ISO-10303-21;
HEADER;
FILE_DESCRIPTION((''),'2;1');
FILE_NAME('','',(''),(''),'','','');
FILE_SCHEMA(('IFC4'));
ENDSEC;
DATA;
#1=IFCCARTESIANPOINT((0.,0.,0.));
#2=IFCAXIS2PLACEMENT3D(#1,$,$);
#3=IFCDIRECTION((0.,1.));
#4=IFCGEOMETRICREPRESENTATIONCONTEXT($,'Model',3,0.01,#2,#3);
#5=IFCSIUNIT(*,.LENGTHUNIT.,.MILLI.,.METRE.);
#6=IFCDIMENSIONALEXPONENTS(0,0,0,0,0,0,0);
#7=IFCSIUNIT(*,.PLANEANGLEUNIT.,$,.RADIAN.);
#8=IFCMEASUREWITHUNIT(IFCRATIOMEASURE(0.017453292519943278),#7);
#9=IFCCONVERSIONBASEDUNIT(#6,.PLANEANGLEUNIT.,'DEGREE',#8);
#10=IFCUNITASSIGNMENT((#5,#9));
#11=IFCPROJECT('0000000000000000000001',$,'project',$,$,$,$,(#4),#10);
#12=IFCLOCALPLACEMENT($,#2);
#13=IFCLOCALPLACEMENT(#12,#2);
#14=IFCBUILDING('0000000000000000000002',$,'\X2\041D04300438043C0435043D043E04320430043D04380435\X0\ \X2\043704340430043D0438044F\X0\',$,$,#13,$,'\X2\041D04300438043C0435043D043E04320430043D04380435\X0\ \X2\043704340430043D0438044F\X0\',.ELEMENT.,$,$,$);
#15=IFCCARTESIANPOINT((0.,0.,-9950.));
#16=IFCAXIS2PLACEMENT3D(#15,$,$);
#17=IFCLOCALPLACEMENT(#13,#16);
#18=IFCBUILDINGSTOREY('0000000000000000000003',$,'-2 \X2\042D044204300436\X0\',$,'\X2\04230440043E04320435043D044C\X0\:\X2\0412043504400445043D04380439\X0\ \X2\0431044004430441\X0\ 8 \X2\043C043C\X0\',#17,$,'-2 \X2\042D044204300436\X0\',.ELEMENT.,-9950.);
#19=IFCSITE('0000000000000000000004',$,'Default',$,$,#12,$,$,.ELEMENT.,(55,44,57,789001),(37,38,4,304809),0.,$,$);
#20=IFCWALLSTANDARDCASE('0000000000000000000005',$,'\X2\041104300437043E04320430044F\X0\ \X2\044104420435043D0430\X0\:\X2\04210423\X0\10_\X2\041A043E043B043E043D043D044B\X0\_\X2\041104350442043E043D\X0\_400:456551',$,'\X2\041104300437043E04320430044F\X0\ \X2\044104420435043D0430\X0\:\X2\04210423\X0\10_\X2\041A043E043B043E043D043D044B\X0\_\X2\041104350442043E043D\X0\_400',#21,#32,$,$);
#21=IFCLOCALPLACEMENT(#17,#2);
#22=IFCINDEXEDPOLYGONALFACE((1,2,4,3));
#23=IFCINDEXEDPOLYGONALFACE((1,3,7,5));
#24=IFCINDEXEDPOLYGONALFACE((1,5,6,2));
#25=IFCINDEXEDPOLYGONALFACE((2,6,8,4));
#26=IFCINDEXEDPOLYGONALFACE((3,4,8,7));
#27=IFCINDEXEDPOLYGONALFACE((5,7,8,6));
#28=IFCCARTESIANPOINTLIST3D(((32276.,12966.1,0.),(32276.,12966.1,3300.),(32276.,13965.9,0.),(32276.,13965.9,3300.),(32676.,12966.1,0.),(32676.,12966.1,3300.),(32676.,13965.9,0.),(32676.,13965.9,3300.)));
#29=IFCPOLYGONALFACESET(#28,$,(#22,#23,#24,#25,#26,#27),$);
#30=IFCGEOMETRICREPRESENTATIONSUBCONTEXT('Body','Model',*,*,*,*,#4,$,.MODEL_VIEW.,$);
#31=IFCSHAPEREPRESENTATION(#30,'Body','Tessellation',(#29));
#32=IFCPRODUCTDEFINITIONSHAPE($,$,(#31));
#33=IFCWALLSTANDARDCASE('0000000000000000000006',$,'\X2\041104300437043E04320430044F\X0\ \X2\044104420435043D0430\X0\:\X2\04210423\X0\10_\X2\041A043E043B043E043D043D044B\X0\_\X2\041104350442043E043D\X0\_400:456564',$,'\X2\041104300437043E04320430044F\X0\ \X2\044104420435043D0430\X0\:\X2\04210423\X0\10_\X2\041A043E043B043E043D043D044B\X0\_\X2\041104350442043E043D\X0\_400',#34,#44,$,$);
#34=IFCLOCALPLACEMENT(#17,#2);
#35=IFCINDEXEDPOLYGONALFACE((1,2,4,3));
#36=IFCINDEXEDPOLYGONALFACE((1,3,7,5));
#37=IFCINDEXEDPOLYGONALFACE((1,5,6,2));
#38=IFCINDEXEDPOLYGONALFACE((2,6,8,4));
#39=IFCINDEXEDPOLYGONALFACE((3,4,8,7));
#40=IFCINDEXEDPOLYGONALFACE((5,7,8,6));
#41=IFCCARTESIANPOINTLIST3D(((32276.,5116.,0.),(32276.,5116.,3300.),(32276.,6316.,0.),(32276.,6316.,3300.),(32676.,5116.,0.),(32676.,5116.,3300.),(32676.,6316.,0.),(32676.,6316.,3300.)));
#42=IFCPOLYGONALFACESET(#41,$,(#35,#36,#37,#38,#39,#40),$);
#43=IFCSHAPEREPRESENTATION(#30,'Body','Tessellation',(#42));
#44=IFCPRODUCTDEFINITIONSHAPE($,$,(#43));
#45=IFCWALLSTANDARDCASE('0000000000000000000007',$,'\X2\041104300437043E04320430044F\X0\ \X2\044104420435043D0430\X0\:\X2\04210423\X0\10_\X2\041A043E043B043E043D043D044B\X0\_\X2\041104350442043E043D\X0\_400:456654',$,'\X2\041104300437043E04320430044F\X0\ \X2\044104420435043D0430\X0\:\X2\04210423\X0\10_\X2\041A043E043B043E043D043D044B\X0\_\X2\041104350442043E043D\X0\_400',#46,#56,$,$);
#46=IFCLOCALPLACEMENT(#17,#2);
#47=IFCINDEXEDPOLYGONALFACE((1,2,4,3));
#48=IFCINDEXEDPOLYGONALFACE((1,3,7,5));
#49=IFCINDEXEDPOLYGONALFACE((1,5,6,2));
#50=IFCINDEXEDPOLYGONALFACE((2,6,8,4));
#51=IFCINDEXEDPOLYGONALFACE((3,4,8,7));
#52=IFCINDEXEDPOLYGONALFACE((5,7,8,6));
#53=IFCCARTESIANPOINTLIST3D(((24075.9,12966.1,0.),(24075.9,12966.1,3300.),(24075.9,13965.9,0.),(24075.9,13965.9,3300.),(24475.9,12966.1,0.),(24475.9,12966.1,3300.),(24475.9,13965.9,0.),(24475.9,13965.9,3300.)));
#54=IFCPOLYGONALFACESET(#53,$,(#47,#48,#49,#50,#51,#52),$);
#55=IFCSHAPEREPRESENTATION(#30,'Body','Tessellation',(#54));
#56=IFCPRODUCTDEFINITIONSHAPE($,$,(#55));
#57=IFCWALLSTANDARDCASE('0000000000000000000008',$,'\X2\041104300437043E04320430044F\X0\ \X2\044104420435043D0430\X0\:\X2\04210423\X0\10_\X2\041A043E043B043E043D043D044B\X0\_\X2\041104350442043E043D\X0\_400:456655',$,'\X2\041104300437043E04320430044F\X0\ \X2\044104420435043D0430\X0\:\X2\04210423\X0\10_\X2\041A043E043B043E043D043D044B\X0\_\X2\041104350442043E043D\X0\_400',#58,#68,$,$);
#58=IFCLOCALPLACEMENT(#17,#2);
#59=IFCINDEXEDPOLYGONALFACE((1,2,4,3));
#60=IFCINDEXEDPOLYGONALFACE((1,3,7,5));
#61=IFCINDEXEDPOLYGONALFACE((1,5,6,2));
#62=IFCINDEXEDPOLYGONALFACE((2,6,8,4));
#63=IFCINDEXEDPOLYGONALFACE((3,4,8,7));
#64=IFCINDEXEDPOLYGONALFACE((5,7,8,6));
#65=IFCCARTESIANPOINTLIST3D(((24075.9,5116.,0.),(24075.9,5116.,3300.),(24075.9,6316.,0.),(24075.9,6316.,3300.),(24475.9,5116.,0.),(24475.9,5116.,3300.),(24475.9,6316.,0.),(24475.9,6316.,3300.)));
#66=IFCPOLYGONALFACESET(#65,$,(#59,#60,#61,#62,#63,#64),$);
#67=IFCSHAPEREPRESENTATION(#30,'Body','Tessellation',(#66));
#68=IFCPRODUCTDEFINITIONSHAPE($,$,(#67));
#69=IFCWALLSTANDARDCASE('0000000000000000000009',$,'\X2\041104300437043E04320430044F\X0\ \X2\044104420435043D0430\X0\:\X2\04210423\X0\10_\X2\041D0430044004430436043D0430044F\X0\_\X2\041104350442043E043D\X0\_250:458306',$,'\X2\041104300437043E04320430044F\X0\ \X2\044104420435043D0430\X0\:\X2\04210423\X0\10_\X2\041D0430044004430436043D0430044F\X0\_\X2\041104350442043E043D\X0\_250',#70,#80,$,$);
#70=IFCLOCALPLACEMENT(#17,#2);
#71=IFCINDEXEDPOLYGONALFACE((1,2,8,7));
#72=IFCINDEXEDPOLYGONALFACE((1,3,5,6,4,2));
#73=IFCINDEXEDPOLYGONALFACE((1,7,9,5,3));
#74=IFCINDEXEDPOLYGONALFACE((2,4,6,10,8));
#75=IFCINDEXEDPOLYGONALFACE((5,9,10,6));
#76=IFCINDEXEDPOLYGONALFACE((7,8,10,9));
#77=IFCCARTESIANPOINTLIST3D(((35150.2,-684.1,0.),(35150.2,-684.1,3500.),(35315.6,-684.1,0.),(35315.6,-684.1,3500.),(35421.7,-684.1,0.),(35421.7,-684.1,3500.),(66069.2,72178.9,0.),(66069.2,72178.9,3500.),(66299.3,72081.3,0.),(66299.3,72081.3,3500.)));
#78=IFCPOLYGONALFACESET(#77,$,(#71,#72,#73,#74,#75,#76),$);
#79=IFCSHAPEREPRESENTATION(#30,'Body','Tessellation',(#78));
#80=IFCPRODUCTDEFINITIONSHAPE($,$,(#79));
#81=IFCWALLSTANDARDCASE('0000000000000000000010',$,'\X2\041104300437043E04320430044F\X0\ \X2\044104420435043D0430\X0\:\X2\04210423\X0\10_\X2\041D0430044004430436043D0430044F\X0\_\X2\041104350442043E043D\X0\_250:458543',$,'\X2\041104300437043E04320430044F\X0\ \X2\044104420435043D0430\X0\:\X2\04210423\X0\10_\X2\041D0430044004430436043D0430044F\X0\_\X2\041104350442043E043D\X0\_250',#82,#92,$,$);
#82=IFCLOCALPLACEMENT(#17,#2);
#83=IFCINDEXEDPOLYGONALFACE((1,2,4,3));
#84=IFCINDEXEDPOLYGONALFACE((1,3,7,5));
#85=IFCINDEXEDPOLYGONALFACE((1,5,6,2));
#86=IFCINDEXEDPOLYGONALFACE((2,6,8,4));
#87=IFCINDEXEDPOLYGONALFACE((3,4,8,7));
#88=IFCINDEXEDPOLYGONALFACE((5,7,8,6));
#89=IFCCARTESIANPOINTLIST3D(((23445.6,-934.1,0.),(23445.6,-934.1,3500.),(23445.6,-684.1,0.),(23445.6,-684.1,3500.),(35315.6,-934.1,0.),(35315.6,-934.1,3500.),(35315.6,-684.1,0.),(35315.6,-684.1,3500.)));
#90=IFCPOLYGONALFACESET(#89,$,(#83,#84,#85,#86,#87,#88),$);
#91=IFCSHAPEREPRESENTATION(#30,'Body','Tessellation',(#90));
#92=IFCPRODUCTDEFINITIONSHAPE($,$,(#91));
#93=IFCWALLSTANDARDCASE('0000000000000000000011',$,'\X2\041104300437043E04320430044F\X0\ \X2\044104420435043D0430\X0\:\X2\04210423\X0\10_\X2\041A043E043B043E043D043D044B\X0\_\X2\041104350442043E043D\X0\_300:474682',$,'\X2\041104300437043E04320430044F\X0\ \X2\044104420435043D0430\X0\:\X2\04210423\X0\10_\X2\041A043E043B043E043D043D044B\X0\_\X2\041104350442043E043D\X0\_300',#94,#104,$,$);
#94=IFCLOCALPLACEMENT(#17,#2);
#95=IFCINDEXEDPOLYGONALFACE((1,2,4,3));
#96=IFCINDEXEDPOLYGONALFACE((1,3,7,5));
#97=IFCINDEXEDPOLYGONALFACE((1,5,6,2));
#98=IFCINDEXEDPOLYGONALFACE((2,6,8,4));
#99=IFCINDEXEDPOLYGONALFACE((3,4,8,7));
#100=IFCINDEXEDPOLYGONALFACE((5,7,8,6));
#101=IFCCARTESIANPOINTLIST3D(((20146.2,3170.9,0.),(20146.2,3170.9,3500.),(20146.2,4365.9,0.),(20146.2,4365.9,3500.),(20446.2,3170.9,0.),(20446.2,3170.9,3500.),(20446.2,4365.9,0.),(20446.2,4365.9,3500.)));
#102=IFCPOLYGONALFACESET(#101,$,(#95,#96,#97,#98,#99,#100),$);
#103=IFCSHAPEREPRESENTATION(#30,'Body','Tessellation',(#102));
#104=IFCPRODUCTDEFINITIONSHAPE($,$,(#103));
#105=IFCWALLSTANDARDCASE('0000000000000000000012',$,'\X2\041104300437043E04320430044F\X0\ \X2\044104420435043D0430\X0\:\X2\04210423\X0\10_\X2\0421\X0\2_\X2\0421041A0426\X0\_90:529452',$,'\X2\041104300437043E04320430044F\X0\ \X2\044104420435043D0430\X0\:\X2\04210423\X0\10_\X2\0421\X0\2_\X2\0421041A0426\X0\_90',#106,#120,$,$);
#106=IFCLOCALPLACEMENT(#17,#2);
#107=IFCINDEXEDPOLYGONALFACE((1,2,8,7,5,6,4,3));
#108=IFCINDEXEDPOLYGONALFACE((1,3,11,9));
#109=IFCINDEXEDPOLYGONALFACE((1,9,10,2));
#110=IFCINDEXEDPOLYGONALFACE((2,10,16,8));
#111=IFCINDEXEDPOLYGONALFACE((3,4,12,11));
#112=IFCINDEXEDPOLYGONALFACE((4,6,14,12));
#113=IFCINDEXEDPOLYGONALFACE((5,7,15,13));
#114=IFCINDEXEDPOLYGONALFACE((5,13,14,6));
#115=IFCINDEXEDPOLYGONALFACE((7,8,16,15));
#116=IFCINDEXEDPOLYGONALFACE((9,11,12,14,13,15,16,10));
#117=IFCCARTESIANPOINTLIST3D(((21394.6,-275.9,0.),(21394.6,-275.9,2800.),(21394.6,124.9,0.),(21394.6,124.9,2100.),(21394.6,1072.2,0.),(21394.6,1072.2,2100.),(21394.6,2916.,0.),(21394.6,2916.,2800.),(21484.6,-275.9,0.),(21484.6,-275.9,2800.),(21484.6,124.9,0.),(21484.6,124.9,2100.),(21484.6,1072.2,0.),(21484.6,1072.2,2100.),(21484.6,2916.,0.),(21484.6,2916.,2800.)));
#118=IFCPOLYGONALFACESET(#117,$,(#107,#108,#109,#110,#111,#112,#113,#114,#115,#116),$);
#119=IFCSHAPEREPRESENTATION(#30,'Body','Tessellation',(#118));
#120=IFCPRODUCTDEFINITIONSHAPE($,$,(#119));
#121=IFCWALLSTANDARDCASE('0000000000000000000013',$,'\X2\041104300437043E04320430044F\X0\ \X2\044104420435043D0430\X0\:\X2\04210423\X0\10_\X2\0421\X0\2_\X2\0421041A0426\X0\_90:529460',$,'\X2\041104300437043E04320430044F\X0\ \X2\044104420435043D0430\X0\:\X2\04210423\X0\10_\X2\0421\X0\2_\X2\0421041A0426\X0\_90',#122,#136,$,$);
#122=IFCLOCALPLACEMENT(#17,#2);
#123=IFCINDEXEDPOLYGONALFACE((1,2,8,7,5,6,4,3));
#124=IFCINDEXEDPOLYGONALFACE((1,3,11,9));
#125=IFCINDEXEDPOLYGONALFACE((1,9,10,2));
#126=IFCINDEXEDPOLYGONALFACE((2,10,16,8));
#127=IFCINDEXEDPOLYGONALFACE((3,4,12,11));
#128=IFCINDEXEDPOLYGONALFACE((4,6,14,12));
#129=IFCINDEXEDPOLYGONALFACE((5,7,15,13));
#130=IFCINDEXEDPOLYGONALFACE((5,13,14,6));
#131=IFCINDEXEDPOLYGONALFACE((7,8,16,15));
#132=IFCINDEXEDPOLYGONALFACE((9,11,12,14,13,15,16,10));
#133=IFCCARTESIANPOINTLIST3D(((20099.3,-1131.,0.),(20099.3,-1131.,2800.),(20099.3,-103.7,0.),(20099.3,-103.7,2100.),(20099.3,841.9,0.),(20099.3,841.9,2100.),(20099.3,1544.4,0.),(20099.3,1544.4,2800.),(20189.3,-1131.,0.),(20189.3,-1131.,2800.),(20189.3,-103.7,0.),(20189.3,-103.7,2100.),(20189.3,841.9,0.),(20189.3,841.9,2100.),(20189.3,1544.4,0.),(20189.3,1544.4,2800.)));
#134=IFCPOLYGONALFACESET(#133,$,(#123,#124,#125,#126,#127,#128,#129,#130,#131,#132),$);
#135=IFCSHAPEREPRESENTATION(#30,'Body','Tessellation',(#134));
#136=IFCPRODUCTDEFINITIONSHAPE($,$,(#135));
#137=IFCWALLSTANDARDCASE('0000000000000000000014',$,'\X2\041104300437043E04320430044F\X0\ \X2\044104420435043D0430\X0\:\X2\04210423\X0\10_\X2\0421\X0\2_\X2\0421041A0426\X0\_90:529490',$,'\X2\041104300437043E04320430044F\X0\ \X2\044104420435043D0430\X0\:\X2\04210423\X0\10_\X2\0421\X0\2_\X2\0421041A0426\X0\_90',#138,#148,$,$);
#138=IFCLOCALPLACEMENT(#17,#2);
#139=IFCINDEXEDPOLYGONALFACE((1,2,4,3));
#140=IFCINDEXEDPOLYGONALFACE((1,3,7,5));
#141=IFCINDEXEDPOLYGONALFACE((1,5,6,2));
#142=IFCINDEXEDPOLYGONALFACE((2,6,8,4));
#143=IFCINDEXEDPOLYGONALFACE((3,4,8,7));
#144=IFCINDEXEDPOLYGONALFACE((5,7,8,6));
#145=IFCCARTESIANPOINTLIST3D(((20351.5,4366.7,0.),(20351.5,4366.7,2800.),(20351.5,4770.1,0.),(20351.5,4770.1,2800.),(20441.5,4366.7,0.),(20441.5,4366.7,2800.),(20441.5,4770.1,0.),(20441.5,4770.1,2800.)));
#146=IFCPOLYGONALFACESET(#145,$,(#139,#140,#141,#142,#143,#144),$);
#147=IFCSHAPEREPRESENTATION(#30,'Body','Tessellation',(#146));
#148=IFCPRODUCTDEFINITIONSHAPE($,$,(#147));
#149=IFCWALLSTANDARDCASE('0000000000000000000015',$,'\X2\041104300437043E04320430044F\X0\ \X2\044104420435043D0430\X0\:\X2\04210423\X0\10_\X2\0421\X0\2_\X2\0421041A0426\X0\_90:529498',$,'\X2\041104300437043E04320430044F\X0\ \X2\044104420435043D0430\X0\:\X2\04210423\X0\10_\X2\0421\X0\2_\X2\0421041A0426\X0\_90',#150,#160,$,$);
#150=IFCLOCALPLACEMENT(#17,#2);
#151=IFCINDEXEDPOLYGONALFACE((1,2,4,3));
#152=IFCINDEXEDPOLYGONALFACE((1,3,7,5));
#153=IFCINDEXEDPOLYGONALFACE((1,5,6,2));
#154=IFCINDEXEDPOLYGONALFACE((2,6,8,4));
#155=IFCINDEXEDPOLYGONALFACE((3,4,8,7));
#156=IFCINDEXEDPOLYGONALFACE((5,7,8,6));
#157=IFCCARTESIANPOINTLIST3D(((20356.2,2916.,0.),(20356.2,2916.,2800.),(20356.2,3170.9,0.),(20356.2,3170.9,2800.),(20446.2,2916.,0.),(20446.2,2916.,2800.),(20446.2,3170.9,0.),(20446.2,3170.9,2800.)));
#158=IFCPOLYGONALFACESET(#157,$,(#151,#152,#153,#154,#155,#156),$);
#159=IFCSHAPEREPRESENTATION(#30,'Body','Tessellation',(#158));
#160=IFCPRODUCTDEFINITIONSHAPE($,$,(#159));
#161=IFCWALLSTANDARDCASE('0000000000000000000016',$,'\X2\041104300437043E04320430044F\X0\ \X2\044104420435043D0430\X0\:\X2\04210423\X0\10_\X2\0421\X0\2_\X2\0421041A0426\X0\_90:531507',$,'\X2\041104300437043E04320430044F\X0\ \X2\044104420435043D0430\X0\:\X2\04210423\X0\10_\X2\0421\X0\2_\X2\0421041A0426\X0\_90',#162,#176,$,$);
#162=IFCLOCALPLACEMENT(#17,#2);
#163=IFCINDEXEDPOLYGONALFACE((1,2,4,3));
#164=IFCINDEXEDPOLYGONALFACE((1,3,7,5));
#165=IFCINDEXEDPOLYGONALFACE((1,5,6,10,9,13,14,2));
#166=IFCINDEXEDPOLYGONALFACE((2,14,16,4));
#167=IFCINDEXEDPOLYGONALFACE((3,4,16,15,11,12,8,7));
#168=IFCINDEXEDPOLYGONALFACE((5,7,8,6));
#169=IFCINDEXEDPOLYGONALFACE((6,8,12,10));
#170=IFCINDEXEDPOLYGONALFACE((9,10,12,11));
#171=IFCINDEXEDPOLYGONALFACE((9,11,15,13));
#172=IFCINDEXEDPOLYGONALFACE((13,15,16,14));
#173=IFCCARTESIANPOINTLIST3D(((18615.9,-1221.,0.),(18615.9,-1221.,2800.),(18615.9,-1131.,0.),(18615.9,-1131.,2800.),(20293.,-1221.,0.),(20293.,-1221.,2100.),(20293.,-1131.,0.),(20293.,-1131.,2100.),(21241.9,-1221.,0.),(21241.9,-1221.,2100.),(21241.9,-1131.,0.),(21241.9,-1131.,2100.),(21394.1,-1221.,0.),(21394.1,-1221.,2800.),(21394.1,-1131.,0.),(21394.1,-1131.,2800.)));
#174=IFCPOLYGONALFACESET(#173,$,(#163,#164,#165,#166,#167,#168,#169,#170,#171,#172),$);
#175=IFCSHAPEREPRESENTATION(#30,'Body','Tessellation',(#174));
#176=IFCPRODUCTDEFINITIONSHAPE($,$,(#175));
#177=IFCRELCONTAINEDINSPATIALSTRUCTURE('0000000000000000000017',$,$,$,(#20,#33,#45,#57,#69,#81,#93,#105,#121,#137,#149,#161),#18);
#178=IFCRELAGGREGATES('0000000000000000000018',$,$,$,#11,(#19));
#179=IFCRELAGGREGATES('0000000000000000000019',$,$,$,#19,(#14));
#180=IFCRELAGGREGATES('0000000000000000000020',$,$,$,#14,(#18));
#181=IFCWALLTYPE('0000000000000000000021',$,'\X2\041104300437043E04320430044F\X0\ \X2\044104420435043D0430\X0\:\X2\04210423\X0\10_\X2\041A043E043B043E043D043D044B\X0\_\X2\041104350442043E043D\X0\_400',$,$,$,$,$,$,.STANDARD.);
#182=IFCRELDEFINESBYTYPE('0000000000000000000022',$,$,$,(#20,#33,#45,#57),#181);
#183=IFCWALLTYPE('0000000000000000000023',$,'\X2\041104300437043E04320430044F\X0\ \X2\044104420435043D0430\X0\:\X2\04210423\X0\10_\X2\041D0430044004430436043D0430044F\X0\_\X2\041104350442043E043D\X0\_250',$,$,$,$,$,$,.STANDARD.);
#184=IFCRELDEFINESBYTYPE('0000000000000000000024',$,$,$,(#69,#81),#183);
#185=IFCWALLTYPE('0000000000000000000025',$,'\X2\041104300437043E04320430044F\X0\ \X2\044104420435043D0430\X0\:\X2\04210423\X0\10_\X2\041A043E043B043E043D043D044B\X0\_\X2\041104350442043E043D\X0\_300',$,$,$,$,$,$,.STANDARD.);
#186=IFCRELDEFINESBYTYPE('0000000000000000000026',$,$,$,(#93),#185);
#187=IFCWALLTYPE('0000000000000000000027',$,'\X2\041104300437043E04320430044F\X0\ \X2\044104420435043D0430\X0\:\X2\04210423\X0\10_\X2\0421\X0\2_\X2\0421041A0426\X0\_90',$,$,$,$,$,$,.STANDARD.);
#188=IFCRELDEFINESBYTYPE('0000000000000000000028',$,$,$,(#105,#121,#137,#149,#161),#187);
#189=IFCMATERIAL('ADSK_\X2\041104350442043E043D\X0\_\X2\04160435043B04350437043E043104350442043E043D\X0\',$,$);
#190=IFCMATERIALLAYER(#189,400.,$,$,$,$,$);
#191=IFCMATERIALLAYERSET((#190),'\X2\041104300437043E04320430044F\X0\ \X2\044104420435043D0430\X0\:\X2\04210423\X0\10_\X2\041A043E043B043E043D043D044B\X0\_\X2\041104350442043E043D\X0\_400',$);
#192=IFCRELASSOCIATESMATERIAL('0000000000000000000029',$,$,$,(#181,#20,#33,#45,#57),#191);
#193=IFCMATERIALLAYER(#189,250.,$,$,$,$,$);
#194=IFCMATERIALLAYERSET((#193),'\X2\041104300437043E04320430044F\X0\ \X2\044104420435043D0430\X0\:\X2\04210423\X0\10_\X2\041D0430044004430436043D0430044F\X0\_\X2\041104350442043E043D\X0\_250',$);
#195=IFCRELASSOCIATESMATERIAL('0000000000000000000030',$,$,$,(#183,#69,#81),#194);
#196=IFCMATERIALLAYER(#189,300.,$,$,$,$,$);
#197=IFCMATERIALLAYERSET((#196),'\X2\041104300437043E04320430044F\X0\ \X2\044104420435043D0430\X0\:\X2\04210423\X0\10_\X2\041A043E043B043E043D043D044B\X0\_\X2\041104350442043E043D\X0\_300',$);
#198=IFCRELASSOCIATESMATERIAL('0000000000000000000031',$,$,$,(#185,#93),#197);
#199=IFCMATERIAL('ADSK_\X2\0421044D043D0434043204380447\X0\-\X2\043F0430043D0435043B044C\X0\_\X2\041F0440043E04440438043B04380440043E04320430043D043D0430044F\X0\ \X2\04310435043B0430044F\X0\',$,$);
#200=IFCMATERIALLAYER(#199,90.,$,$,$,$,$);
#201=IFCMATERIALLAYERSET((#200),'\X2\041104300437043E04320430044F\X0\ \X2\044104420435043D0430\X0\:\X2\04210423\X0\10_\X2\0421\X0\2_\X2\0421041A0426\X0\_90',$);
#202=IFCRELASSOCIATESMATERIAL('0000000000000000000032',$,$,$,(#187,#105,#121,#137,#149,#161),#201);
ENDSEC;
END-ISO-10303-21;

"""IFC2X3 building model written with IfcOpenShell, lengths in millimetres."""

from ifc_helpers import new_model, entity, si_unit, converted_unit, direction, frame, frame_2d, origin, place, context, subcontext, project, spatial, polyline, rectangle, outline, extrude, material, layer, layer_set, layer_usage, type_object, element, save


model = new_model("IFC2X3")

# Units and contexts
model_context = context("Model", 3, precision=0.01, world=origin(), true_north=direction((0.0, 1.0)))
body_context = subcontext(model_context, "Body", "Model", "MODEL_VIEW")
ifc_project = project(units=[si_unit("LENGTHUNIT", "METRE", prefix="MILLI"), converted_unit("PLANEANGLEUNIT", "DEGREE", entity("IfcRatioMeasure", 0.017453292519943278), si_unit("PLANEANGLEUNIT", "RADIAN"), dimensions=[0, 0, 0, 0, 0, 0, 0])], contexts=[model_context])

# Site, building, storey
site_placement = place(None, origin())
site = spatial("IfcSite", under=ifc_project, at=site_placement, Name="Default", CompositionType="ELEMENT", RefLatitude=(55, 44, 57, 789001), RefLongitude=(37, 38, 4, 304809), RefElevation=0.0)
building_placement = place(site_placement, origin())
building = spatial("IfcBuilding", under=site, at=building_placement, Name="Наименование здания", LongName="Наименование здания", CompositionType="ELEMENT")
storey_placement = place(building_placement, frame((0.0, 0.0, -9950.0)))
storey = spatial("IfcBuildingStorey", under=building, at=storey_placement, Name="-2 Этаж", ObjectType="Уровень:Верхний брус 8 мм", LongName="-2 Этаж", CompositionType="ELEMENT", Elevation=-9950.0)

# Walls
ifc_material_1 = material(Name="ADSK_Бетон_Железобетон")
ifc_layer_1 = layer(ifc_material_1, 400.0)
ifc_layer_set_1 = layer_set([ifc_layer_1], Name="Базовая стена:СУ10_Колонны_Бетон_400")
ifc_layer_usage_1 = layer_usage(ifc_layer_set_1, "AXIS2", "NEGATIVE", 200.0)
wall_type_1 = type_object("IfcWallType", Name="Базовая стена:СУ10_Колонны_Бетон_400", PredefinedType="STANDARD", material=ifc_layer_set_1)
wall_1_placement = place(storey_placement, frame((32476.0, 12966.1, 0.0), z_axis=(0.0, 0.0, 1.0), x_axis=(0.0, 1.0, 0.0)))
element("IfcWallStandardCase", 1, at=wall_1_placement, inside=storey, type_object=wall_type_1, material=ifc_layer_usage_1, Name="Базовая стена:СУ10_Колонны_Бетон_400:456551", ObjectType="Базовая стена:СУ10_Колонны_Бетон_400", context=body_context, shape_type="SweptSolid", body=[
    extrude(rectangle(XDim=999.8, YDim=400.0, at=frame_2d((499.9, 0.0), x_axis=(-1.0, 0.0))), origin(), (0.0, 0.0, 1.0), 3300.0),
])
wall_2_placement = place(storey_placement, frame((32476.0, 5116.0, 0.0), z_axis=(0.0, 0.0, 1.0), x_axis=(0.0, 1.0, 0.0)))
element("IfcWallStandardCase", 2, at=wall_2_placement, inside=storey, type_object=wall_type_1, material=ifc_layer_usage_1, Name="Базовая стена:СУ10_Колонны_Бетон_400:456564", ObjectType="Базовая стена:СУ10_Колонны_Бетон_400", context=body_context, shape_type="SweptSolid", body=[
    extrude(rectangle(XDim=1200.0, YDim=400.0, at=frame_2d((600.0, 0.0), x_axis=(-1.0, 0.0))), origin(), (0.0, 0.0, 1.0), 3300.0),
])
wall_3_placement = place(storey_placement, frame((24275.9, 12966.1, 0.0), z_axis=(0.0, 0.0, 1.0), x_axis=(0.0, 1.0, 0.0)))
element("IfcWallStandardCase", 3, at=wall_3_placement, inside=storey, type_object=wall_type_1, material=ifc_layer_usage_1, Name="Базовая стена:СУ10_Колонны_Бетон_400:456654", ObjectType="Базовая стена:СУ10_Колонны_Бетон_400", context=body_context, shape_type="SweptSolid", body=[
    extrude(rectangle(XDim=999.8, YDim=400.0, at=frame_2d((499.9, 0.0), x_axis=(-1.0, 0.0))), origin(), (0.0, 0.0, 1.0), 3300.0),
])
wall_4_placement = place(storey_placement, frame((24275.9, 5116.0, 0.0), z_axis=(0.0, 0.0, 1.0), x_axis=(0.0, 1.0, 0.0)))
element("IfcWallStandardCase", 4, at=wall_4_placement, inside=storey, type_object=wall_type_1, material=ifc_layer_usage_1, Name="Базовая стена:СУ10_Колонны_Бетон_400:456655", ObjectType="Базовая стена:СУ10_Колонны_Бетон_400", context=body_context, shape_type="SweptSolid", body=[
    extrude(rectangle(XDim=1200.0, YDim=400.0, at=frame_2d((600.0, 0.0), x_axis=(-1.0, 0.0))), origin(), (0.0, 0.0, 1.0), 3300.0),
])
ifc_layer_2 = layer(ifc_material_1, 250.0)
ifc_layer_set_2 = layer_set([ifc_layer_2], Name="Базовая стена:СУ10_Наружная_Бетон_250")
ifc_layer_usage_2 = layer_usage(ifc_layer_set_2, "AXIS2", "NEGATIVE", 125.0)
wall_type_2 = type_object("IfcWallType", Name="Базовая стена:СУ10_Наружная_Бетон_250", PredefinedType="STANDARD", material=ifc_layer_set_2)
wall_5_placement = place(storey_placement, frame((35265.2, -732.9, 0.0), z_axis=(0.0, 0.0, 1.0), x_axis=(0.390629, 0.920548, 0.0)))
element("IfcWallStandardCase", 5, at=wall_5_placement, inside=storey, type_object=wall_type_2, material=ifc_layer_usage_2, Name="Базовая стена:СУ10_Наружная_Бетон_250:458306", ObjectType="Базовая стена:СУ10_Наружная_Бетон_250", context=body_context, shape_type="SweptSolid", body=[
    extrude(outline(polyline([(79151.7, -125.0), (79151.7, 125.0), (0.0, 125.0), (64.6, -27.3), (106.1, -125.0), (79151.7, -125.0)])), origin(), (0.0, 0.0, 1.0), 3500.0),
])
wall_6_placement = place(storey_placement, frame((23445.6, -809.1, 0.0)))
element("IfcWallStandardCase", 6, at=wall_6_placement, inside=storey, type_object=wall_type_2, material=ifc_layer_usage_2, Name="Базовая стена:СУ10_Наружная_Бетон_250:458543", ObjectType="Базовая стена:СУ10_Наружная_Бетон_250", context=body_context, shape_type="SweptSolid", body=[
    extrude(rectangle(XDim=11870.0, YDim=250.0, at=frame_2d((5935.0, 0.0), x_axis=(-1.0, 0.0))), origin(), (0.0, 0.0, 1.0), 3500.0),
])
ifc_layer_3 = layer(ifc_material_1, 300.0)
ifc_layer_set_3 = layer_set([ifc_layer_3], Name="Базовая стена:СУ10_Колонны_Бетон_300")
ifc_layer_usage_3 = layer_usage(ifc_layer_set_3, "AXIS2", "NEGATIVE", 150.0)
wall_type_3 = type_object("IfcWallType", Name="Базовая стена:СУ10_Колонны_Бетон_300", PredefinedType="STANDARD", material=ifc_layer_set_3)
wall_7_placement = place(storey_placement, frame((20296.2, 3170.9, 0.0), z_axis=(0.0, 0.0, 1.0), x_axis=(0.0, 1.0, 0.0)))
element("IfcWallStandardCase", 7, at=wall_7_placement, inside=storey, type_object=wall_type_3, material=ifc_layer_usage_3, Name="Базовая стена:СУ10_Колонны_Бетон_300:474682", ObjectType="Базовая стена:СУ10_Колонны_Бетон_300", context=body_context, shape_type="SweptSolid", body=[
    extrude(rectangle(XDim=1195.0, YDim=300.0, at=frame_2d((597.5, 0.0), x_axis=(-1.0, 0.0))), origin(), (0.0, 0.0, 1.0), 3500.0),
])

# Walls, openings
ifc_material_2 = material(Name="ADSK_Сэндвич-панель_Профилированная белая")
ifc_layer_4 = layer(ifc_material_2, 90.0)
ifc_layer_set_4 = layer_set([ifc_layer_4], Name="Базовая стена:СУ10_С2_СКЦ_90")
ifc_layer_usage_4 = layer_usage(ifc_layer_set_4, "AXIS2", "NEGATIVE", 45.0)
wall_type_4 = type_object("IfcWallType", Name="Базовая стена:СУ10_С2_СКЦ_90", PredefinedType="STANDARD", material=ifc_layer_set_4)
wall_8_placement = place(storey_placement, frame((21439.6, 2916.0, 0.0), z_axis=(0.0, 0.0, 1.0), x_axis=(0.0, -1.0, 0.0)))
wall_8 = element("IfcWallStandardCase", 8, at=wall_8_placement, inside=storey, type_object=wall_type_4, material=ifc_layer_usage_4, Name="Базовая стена:СУ10_С2_СКЦ_90:529452", ObjectType="Базовая стена:СУ10_С2_СКЦ_90", context=body_context, shape_type="SweptSolid", body=[
    extrude(rectangle(XDim=3191.8, YDim=90.0, at=frame_2d((1595.9, 0.0), x_axis=(1.0, 0.0))), origin(), (0.0, 0.0, 1.0), 2800.0),
])
opening_1_placement = place(wall_8_placement, origin())
element("IfcOpeningElement", 9, at=opening_1_placement, cuts=wall_8, ObjectType="Opening", context=body_context, shape_type="SweptSolid", body=[
    extrude(rectangle(XDim=2100.0, YDim=947.3, at=frame_2d((0.0, 0.0), x_axis=(1.0, 0.0))), frame((2317.5, -45.0, 1050.0), z_axis=(0.0, 1.0, 0.0), x_axis=(0.0, 0.0, -1.0)), (0.0, 0.0, 1.0), 90.0),
])
wall_9_placement = place(storey_placement, frame((20144.3, 1544.4, 0.0), z_axis=(0.0, 0.0, 1.0), x_axis=(0.0, -1.0, 0.0)))
wall_9 = element("IfcWallStandardCase", 10, at=wall_9_placement, inside=storey, type_object=wall_type_4, material=ifc_layer_usage_4, Name="Базовая стена:СУ10_С2_СКЦ_90:529460", ObjectType="Базовая стена:СУ10_С2_СКЦ_90", context=body_context, shape_type="SweptSolid", body=[
    extrude(rectangle(XDim=2675.4, YDim=90.0, at=frame_2d((1337.7, 0.0), x_axis=(1.0, 0.0))), origin(), (0.0, 0.0, 1.0), 2800.0),
])
opening_2_placement = place(wall_9_placement, origin())
element("IfcOpeningElement", 11, at=opening_2_placement, cuts=wall_9, ObjectType="Opening", context=body_context, shape_type="SweptSolid", body=[
    extrude(rectangle(XDim=2100.0, YDim=945.6, at=frame_2d((0.0, 0.0), x_axis=(1.0, 0.0))), frame((1175.3, -45.0, 1050.0), z_axis=(0.0, 1.0, 0.0), x_axis=(0.0, 0.0, -1.0)), (0.0, 0.0, 1.0), 90.0),
])

# Walls
wall_10_placement = place(storey_placement, frame((20396.5, 4770.1, 0.0), z_axis=(0.0, 0.0, 1.0), x_axis=(0.0, -1.0, 0.0)))
element("IfcWallStandardCase", 12, at=wall_10_placement, inside=storey, type_object=wall_type_4, material=ifc_layer_usage_4, Name="Базовая стена:СУ10_С2_СКЦ_90:529490", ObjectType="Базовая стена:СУ10_С2_СКЦ_90", context=body_context, shape_type="SweptSolid", body=[
    extrude(rectangle(XDim=403.5, YDim=90.0, at=frame_2d((201.7, 0.0), x_axis=(-1.0, 0.0))), origin(), (0.0, 0.0, 1.0), 2800.0),
])
wall_11_placement = place(storey_placement, frame((20401.2, 3170.9, 0.0), z_axis=(0.0, 0.0, 1.0), x_axis=(0.0, -1.0, 0.0)))
element("IfcWallStandardCase", 13, at=wall_11_placement, inside=storey, type_object=wall_type_4, material=ifc_layer_usage_4, Name="Базовая стена:СУ10_С2_СКЦ_90:529498", ObjectType="Базовая стена:СУ10_С2_СКЦ_90", context=body_context, shape_type="SweptSolid", body=[
    extrude(rectangle(XDim=254.9, YDim=90.0, at=frame_2d((127.5, 0.0), x_axis=(-1.0, 0.0))), origin(), (0.0, 0.0, 1.0), 2800.0),
])

# Wall, opening
wall_12_placement = place(storey_placement, frame((21394.1, -1176.0, 0.0), z_axis=(0.0, 0.0, 1.0), x_axis=(-1.0, 0.0, 0.0)))
wall_12 = element("IfcWallStandardCase", 14, at=wall_12_placement, inside=storey, type_object=wall_type_4, material=ifc_layer_usage_4, Name="Базовая стена:СУ10_С2_СКЦ_90:531507", ObjectType="Базовая стена:СУ10_С2_СКЦ_90", context=body_context, shape_type="SweptSolid", body=[
    extrude(rectangle(XDim=2778.2, YDim=90.0, at=frame_2d((1389.1, 0.0), x_axis=(-1.0, 0.0))), origin(), (0.0, 0.0, 1.0), 2800.0),
])
opening_3_placement = place(wall_12_placement, origin())
element("IfcOpeningElement", 15, at=opening_3_placement, cuts=wall_12, ObjectType="Opening", context=body_context, shape_type="SweptSolid", body=[
    extrude(rectangle(XDim=2100.0, YDim=948.9, at=frame_2d((0.0, 0.0), x_axis=(1.0, 0.0))), frame((626.6, -45.0, 1050.0), z_axis=(0.0, 1.0, 0.0), x_axis=(0.0, 0.0, -1.0)), (0.0, 0.0, 1.0), 90.0),
])

save(model, "model.ifc")
